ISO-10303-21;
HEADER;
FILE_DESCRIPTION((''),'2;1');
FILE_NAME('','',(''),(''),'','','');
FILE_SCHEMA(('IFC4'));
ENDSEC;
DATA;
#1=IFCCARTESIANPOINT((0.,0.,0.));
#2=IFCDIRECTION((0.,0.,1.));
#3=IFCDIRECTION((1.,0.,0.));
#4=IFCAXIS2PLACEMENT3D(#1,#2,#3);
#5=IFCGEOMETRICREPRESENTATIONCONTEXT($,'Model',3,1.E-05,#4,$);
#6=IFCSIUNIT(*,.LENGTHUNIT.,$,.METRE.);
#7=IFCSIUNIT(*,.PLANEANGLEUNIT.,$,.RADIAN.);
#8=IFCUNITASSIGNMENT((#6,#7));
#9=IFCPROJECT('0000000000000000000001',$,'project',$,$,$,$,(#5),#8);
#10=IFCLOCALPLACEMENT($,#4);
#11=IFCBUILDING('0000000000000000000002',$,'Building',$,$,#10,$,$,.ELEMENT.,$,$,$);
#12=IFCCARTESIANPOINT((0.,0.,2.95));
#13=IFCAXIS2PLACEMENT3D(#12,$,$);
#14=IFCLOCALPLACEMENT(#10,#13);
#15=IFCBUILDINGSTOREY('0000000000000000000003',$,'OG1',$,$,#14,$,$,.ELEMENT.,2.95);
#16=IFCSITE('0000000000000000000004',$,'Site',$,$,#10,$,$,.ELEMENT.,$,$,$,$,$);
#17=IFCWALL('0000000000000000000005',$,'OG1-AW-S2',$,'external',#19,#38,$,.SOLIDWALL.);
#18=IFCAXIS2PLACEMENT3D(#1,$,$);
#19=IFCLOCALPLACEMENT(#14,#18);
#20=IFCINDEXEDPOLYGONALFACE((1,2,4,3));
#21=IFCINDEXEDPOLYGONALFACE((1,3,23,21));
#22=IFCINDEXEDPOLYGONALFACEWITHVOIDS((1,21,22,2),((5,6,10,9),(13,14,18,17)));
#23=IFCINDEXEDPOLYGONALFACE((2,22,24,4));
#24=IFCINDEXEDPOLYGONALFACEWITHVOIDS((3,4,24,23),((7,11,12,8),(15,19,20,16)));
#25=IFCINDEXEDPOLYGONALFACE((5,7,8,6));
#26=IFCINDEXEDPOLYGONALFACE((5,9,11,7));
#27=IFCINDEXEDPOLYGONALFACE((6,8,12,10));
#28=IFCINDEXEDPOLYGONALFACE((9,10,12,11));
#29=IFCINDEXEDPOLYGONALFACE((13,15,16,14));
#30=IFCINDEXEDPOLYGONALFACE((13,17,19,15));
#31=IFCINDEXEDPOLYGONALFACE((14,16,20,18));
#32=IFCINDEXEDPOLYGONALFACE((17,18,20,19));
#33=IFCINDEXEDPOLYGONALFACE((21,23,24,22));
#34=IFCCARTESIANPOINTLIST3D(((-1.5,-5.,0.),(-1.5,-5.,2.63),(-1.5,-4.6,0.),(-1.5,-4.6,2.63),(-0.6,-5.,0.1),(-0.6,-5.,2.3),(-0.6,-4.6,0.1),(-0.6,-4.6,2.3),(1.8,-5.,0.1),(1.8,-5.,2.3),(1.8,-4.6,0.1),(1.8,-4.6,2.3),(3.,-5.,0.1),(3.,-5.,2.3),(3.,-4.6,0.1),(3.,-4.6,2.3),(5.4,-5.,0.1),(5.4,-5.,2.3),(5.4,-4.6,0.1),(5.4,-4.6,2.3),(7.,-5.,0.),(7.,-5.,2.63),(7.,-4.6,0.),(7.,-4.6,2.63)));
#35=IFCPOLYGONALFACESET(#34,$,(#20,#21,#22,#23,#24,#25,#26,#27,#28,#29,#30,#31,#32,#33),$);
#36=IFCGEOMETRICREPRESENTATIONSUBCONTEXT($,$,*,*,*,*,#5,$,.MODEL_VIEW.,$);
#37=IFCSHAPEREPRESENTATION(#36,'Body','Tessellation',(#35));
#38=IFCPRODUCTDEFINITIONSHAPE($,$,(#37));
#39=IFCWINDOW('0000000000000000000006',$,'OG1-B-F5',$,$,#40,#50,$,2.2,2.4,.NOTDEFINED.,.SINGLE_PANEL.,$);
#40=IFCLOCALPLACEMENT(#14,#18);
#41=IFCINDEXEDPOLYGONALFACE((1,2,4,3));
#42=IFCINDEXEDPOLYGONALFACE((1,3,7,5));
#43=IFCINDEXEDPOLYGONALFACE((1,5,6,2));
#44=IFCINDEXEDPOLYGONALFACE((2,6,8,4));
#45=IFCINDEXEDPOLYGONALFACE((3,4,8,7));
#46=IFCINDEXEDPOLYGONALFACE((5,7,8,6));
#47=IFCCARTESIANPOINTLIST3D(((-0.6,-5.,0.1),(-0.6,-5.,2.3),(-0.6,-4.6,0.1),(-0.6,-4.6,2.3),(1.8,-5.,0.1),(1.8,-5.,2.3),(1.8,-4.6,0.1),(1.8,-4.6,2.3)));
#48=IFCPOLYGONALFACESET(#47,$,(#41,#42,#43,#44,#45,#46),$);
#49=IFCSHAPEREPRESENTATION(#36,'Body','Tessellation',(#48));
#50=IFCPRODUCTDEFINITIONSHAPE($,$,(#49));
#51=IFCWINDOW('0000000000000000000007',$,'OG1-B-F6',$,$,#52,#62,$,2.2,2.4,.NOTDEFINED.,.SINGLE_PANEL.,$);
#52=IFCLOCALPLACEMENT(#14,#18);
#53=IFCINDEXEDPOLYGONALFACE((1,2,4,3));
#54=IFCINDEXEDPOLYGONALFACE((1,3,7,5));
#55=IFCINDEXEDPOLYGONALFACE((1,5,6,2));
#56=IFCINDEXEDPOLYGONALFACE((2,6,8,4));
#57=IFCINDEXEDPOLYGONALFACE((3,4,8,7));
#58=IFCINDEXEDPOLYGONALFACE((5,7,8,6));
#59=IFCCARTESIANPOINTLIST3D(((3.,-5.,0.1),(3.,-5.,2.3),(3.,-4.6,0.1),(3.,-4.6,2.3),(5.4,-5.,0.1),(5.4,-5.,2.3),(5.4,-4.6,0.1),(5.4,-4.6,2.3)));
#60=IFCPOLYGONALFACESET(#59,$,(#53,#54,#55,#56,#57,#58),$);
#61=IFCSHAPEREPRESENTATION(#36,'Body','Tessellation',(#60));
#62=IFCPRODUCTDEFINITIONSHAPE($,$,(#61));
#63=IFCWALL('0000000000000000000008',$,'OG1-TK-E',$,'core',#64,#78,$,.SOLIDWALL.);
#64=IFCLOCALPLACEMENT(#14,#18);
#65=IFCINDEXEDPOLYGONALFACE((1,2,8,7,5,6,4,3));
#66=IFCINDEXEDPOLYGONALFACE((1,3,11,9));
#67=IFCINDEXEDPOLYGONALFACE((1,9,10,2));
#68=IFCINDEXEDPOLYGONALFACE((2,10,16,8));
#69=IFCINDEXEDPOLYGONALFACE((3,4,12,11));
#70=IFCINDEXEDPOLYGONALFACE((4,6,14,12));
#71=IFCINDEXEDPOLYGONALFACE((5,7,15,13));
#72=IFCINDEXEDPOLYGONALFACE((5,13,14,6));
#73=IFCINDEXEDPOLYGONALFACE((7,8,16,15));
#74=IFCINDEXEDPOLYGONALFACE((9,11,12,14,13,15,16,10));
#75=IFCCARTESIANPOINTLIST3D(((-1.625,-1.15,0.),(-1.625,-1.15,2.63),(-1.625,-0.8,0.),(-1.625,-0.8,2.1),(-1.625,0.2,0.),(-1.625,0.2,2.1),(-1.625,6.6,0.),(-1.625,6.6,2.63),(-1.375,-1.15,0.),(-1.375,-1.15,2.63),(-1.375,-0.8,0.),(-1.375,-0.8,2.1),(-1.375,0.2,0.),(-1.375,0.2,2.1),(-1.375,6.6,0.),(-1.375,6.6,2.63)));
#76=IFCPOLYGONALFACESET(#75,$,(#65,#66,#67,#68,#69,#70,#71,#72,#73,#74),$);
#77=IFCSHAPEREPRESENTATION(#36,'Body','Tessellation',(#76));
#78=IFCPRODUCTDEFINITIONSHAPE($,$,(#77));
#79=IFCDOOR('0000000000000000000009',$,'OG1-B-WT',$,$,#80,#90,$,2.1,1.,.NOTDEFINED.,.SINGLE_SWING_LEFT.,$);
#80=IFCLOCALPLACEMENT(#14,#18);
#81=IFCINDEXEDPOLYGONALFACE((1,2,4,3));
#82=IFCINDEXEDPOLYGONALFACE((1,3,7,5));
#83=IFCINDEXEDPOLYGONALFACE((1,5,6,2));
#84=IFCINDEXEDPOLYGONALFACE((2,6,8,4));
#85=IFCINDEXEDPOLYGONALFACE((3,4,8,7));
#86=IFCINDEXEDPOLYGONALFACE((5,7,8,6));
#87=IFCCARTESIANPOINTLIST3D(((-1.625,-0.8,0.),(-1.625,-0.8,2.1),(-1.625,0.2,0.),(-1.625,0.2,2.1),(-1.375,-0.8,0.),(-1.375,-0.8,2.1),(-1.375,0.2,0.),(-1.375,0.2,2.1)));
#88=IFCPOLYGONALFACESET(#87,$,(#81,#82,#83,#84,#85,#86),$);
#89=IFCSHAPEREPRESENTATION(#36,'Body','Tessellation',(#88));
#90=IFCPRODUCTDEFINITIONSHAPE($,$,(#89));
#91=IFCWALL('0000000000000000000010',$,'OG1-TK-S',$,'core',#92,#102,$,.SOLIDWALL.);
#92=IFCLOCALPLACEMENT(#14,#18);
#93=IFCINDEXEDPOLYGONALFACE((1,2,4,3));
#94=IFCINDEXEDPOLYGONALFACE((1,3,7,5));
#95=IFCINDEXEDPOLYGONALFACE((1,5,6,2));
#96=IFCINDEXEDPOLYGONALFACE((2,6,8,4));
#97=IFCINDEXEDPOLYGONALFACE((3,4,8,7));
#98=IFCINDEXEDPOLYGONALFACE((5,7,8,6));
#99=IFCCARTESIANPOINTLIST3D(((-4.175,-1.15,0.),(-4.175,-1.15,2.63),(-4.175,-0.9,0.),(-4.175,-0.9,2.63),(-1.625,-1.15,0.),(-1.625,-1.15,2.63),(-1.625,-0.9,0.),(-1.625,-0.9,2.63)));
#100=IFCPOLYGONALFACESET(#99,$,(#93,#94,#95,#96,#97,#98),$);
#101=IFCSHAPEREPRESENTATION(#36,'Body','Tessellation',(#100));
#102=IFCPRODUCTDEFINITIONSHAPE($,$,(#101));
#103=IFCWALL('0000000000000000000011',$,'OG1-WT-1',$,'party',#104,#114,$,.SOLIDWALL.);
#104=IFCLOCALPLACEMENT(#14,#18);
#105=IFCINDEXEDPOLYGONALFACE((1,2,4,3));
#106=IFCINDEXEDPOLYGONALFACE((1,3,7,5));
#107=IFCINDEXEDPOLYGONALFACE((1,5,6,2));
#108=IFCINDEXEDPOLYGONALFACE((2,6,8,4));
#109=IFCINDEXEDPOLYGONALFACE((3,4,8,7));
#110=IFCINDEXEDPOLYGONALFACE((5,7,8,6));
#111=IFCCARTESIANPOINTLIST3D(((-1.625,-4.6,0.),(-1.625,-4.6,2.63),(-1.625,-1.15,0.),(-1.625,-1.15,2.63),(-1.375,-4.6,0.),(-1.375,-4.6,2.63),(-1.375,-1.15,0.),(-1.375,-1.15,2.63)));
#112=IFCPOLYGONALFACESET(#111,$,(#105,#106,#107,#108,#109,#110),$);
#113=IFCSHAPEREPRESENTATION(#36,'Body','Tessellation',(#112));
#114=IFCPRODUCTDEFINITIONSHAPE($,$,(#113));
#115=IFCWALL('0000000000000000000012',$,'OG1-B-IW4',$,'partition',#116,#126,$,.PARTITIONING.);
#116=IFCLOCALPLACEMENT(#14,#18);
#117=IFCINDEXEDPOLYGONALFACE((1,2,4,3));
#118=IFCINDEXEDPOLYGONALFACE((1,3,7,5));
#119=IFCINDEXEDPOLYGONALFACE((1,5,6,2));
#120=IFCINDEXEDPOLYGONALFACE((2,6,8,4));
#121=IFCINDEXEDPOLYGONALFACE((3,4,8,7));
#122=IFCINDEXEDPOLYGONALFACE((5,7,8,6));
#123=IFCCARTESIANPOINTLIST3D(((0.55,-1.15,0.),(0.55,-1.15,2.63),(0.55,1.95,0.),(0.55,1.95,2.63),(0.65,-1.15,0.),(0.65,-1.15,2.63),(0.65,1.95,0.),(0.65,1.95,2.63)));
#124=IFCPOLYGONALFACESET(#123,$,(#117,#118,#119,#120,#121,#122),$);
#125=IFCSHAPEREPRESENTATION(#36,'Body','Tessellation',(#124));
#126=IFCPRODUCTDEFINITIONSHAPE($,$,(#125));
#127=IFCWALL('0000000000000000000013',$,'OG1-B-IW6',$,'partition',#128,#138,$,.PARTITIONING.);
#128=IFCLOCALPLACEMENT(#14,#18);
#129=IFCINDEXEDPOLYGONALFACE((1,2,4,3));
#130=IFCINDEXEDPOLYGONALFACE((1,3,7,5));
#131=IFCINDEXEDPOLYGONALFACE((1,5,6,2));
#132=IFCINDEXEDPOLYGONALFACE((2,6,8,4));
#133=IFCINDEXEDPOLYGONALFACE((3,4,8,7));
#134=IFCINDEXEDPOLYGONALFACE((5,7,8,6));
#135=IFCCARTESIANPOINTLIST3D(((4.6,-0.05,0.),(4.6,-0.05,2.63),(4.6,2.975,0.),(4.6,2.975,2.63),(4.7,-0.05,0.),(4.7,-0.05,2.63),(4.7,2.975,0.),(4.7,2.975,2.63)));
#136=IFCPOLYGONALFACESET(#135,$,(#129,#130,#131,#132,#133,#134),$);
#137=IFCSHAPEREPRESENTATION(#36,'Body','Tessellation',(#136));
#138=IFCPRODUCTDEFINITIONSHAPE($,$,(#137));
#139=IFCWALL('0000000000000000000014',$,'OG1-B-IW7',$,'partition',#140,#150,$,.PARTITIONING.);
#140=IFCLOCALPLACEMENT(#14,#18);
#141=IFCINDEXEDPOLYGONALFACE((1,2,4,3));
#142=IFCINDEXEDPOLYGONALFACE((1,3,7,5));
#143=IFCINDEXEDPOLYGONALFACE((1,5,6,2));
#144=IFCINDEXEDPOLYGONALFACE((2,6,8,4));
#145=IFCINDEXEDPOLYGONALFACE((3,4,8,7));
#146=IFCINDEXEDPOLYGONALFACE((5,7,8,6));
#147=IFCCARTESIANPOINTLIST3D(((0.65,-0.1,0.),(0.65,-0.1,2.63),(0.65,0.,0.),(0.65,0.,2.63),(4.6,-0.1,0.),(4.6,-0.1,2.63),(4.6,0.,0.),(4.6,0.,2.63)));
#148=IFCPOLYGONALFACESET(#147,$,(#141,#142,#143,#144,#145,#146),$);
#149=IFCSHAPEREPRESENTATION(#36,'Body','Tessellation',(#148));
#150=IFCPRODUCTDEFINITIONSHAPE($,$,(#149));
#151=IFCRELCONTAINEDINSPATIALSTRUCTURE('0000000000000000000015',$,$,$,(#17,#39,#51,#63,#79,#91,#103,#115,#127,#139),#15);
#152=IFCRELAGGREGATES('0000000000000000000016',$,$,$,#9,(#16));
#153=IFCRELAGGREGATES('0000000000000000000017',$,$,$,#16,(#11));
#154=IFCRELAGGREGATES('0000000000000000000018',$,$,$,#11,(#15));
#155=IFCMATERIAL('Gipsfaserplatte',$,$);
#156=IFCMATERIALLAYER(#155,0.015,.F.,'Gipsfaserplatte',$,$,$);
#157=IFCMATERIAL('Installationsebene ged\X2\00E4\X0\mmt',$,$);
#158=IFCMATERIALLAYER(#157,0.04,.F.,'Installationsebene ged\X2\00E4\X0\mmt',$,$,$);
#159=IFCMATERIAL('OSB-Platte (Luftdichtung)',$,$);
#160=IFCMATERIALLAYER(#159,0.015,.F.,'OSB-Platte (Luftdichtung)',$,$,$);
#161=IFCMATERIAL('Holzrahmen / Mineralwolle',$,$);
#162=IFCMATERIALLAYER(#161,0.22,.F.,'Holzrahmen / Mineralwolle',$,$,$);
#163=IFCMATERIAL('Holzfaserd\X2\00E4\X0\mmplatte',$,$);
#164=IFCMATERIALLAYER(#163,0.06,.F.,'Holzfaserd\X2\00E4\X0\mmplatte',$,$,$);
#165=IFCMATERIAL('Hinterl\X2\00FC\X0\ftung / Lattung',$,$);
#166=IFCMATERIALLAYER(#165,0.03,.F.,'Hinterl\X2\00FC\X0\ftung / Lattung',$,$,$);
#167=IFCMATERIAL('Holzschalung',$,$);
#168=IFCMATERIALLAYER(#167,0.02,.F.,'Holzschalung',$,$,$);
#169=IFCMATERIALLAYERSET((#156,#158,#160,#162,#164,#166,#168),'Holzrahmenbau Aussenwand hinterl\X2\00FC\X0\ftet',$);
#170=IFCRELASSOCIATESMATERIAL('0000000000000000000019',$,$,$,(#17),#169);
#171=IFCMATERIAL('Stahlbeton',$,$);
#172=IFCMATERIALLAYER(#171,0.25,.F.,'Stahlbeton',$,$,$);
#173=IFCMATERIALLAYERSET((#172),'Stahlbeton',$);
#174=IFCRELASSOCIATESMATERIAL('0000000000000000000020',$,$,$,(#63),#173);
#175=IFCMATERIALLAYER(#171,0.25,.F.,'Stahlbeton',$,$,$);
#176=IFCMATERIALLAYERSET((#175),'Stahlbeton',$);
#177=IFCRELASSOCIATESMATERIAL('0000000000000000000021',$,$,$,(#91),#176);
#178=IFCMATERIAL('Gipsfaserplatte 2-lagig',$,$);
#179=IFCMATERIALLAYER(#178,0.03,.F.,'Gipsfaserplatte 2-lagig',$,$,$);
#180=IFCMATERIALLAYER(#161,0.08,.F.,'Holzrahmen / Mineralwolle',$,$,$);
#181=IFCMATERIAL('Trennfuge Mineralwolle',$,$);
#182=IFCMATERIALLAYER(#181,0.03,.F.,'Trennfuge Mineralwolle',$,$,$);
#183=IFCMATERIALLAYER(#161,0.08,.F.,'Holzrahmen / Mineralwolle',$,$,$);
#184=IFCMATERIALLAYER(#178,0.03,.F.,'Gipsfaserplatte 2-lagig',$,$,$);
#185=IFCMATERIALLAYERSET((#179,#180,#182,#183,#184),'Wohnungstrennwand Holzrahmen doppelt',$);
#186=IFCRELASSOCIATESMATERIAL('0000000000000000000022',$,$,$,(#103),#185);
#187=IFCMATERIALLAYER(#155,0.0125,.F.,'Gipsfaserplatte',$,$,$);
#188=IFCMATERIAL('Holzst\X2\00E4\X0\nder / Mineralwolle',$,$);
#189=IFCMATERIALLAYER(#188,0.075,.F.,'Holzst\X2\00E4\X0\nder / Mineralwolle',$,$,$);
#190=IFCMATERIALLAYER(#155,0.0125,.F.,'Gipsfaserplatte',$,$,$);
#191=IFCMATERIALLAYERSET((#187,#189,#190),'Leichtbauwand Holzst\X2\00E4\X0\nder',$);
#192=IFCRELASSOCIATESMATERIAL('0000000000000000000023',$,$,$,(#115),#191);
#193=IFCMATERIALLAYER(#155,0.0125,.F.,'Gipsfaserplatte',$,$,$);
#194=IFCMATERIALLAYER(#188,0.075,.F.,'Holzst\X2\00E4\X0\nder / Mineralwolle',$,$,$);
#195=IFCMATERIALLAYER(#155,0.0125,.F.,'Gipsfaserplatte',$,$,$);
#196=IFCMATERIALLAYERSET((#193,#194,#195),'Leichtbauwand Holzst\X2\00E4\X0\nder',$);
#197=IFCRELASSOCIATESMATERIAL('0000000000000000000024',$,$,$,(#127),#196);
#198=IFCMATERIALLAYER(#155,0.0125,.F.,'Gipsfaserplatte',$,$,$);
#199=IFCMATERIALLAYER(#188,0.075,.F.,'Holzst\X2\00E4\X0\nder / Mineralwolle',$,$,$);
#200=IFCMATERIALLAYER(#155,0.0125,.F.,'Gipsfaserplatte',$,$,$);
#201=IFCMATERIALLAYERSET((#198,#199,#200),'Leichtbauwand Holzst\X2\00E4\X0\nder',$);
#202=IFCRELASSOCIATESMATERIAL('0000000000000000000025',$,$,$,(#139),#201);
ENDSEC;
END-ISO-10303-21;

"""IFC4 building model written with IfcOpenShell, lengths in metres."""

from ifc_helpers import new_model, si_unit, frame, frame_2d, origin, origin_with_axes, place, context, subcontext, project, spatial, rectangle, extrude, material, layer, layer_set, element, fill, save


model = new_model("IFC4")

# Units and contexts
model_context = context("Model", 3, precision=1e-05, world=origin_with_axes())
sub_context = subcontext(model_context, None, None, "MODEL_VIEW")
ifc_project = project(units=[si_unit("LENGTHUNIT", "METRE"), si_unit("PLANEANGLEUNIT", "RADIAN")], contexts=[model_context])

# Site, building, storey
placement = place(None, origin_with_axes())
site = spatial("IfcSite", under=ifc_project, at=placement, Name="Site", CompositionType="ELEMENT")
building = spatial("IfcBuilding", under=site, at=placement, Name="Building", CompositionType="ELEMENT")
storey_placement = place(placement, frame((0.0, 0.0, 2.95)))
storey = spatial("IfcBuildingStorey", under=building, at=storey_placement, Name="OG1", CompositionType="ELEMENT", Elevation=2.95)

# Wall, openings, windows
ifc_material_1 = material(Name="Gipsfaserplatte")
ifc_layer_1 = layer(ifc_material_1, 0.015, ventilated=False, Name="Gipsfaserplatte")
ifc_material_2 = material(Name="Installationsebene gedämmt")
ifc_layer_2 = layer(ifc_material_2, 0.04, ventilated=False, Name="Installationsebene gedämmt")
ifc_material_3 = material(Name="OSB-Platte (Luftdichtung)")
ifc_layer_3 = layer(ifc_material_3, 0.015, ventilated=False, Name="OSB-Platte (Luftdichtung)")
ifc_material_4 = material(Name="Holzrahmen / Mineralwolle")
ifc_layer_4 = layer(ifc_material_4, 0.22, ventilated=False, Name="Holzrahmen / Mineralwolle")
ifc_material_5 = material(Name="Holzfaserdämmplatte")
ifc_layer_5 = layer(ifc_material_5, 0.06, ventilated=False, Name="Holzfaserdämmplatte")
ifc_material_6 = material(Name="Hinterlüftung / Lattung")
ifc_layer_6 = layer(ifc_material_6, 0.03, ventilated=False, Name="Hinterlüftung / Lattung")
ifc_material_7 = material(Name="Holzschalung")
ifc_layer_7 = layer(ifc_material_7, 0.02, ventilated=False, Name="Holzschalung")
ifc_layer_set_1 = layer_set([ifc_layer_1, ifc_layer_2, ifc_layer_3, ifc_layer_4, ifc_layer_5, ifc_layer_6, ifc_layer_7], Name="Holzrahmenbau Aussenwand hinterlüftet")
wall_1_placement = place(storey_placement, frame((7.0, -4.8, 0.0), z_axis=(0.0, 0.0, 1.0), x_axis=(-1.0, 0.0, 0.0)))
wall_1 = element("IfcWall", 1, at=wall_1_placement, inside=storey, material=ifc_layer_set_1, Name="OG1-AW-S2", ObjectType="external", PredefinedType="SOLIDWALL", context=sub_context, shape_type="SweptSolid", body=[
    extrude(rectangle(XDim=8.5, YDim=0.4, at=frame_2d((4.25, 0.0))), origin(), (0.0, 0.0, 1.0), 2.63),
])
opening_1_placement = place(wall_1_placement, frame((6.4, 0.25, 0.1), z_axis=(0.0, -1.0, 0.0), x_axis=(1.0, 0.0, 0.0)))
opening_1 = element("IfcOpeningElement", 2, at=opening_1_placement, cuts=wall_1, PredefinedType="OPENING", context=sub_context, shape_type="SweptSolid", body=[
    extrude(rectangle(XDim=2.4, YDim=2.2, at=frame_2d((0.0, 1.1))), origin(), (0.0, 0.0, 1.0), 0.5),
])
opening_2_placement = place(wall_1_placement, frame((2.8, 0.25, 0.1), z_axis=(0.0, -1.0, 0.0), x_axis=(1.0, 0.0, 0.0)))
opening_2 = element("IfcOpeningElement", 3, at=opening_2_placement, cuts=wall_1, PredefinedType="OPENING", context=sub_context, shape_type="SweptSolid", body=[
    extrude(rectangle(XDim=2.4, YDim=2.2, at=frame_2d((0.0, 1.1))), origin(), (0.0, 0.0, 1.0), 0.5),
])
window_1_placement = place(wall_1_placement, frame((6.4, 0.2, 0.1), z_axis=(0.0, -1.0, 0.0), x_axis=(1.0, 0.0, 0.0)))
window_1 = element("IfcWindow", 4, at=window_1_placement, inside=storey, Name="OG1-B-F5", OverallHeight=2.2, OverallWidth=2.4, PartitioningType="SINGLE_PANEL", PredefinedType="NOTDEFINED", context=sub_context, shape_type="SweptSolid", body=[
    extrude(rectangle(XDim=2.4, YDim=2.2, at=frame_2d((0.0, 1.1))), origin(), (0.0, 0.0, 1.0), 0.4),
])
fill(opening_1, window_1)
window_2_placement = place(wall_1_placement, frame((2.8, 0.2, 0.1), z_axis=(0.0, -1.0, 0.0), x_axis=(1.0, 0.0, 0.0)))
window_2 = element("IfcWindow", 5, at=window_2_placement, inside=storey, Name="OG1-B-F6", OverallHeight=2.2, OverallWidth=2.4, PartitioningType="SINGLE_PANEL", PredefinedType="NOTDEFINED", context=sub_context, shape_type="SweptSolid", body=[
    extrude(rectangle(XDim=2.4, YDim=2.2, at=frame_2d((0.0, 1.1))), origin(), (0.0, 0.0, 1.0), 0.4),
])
fill(opening_2, window_2)

# Wall, opening, door
ifc_material_8 = material(Name="Stahlbeton")
ifc_layer_8 = layer(ifc_material_8, 0.25, ventilated=False, Name="Stahlbeton")
ifc_layer_set_2 = layer_set([ifc_layer_8], Name="Stahlbeton")
wall_2_placement = place(storey_placement, frame((-1.5, -1.15, 0.0), z_axis=(0.0, 0.0, 1.0), x_axis=(0.0, 1.0, 0.0)))
wall_2 = element("IfcWall", 6, at=wall_2_placement, inside=storey, material=ifc_layer_set_2, Name="OG1-TK-E", ObjectType="core", PredefinedType="SOLIDWALL", context=sub_context, shape_type="SweptSolid", body=[
    extrude(rectangle(XDim=7.75, YDim=0.25, at=frame_2d((3.875, 0.0))), origin(), (0.0, 0.0, 1.0), 2.63),
])
opening_3_placement = place(wall_2_placement, frame((0.85, 0.175, 0.0), z_axis=(0.0, -1.0, 0.0), x_axis=(1.0, 0.0, 0.0)))
opening_3 = element("IfcOpeningElement", 7, at=opening_3_placement, cuts=wall_2, PredefinedType="OPENING", context=sub_context, shape_type="SweptSolid", body=[
    extrude(rectangle(XDim=1.0, YDim=2.1, at=frame_2d((0.0, 1.05))), origin(), (0.0, 0.0, 1.0), 0.35),
])
door_1_placement = place(wall_2_placement, frame((0.85, 0.125, 0.0), z_axis=(0.0, -1.0, 0.0), x_axis=(1.0, 0.0, 0.0)))
door_1 = element("IfcDoor", 8, at=door_1_placement, inside=storey, Name="OG1-B-WT", OperationType="SINGLE_SWING_LEFT", OverallHeight=2.1, OverallWidth=1.0, PredefinedType="NOTDEFINED", context=sub_context, shape_type="SweptSolid", body=[
    extrude(rectangle(XDim=1.0, YDim=2.1, at=frame_2d((0.0, 1.05))), origin(), (0.0, 0.0, 1.0), 0.25),
])
fill(opening_3, door_1)

# Walls
ifc_layer_9 = layer(ifc_material_8, 0.25, ventilated=False, Name="Stahlbeton")
ifc_layer_set_3 = layer_set([ifc_layer_9], Name="Stahlbeton")
wall_3_placement = place(storey_placement, frame((-4.175, -1.025, 0.0), z_axis=(0.0, 0.0, 1.0), x_axis=(1.0, 0.0, 0.0)))
element("IfcWall", 9, at=wall_3_placement, inside=storey, material=ifc_layer_set_3, Name="OG1-TK-S", ObjectType="core", PredefinedType="SOLIDWALL", context=sub_context, shape_type="SweptSolid", body=[
    extrude(rectangle(XDim=2.55, YDim=0.25, at=frame_2d((1.275, 0.0))), origin(), (0.0, 0.0, 1.0), 2.63),
])
ifc_material_9 = material(Name="Gipsfaserplatte 2-lagig")
ifc_layer_10 = layer(ifc_material_9, 0.03, ventilated=False, Name="Gipsfaserplatte 2-lagig")
ifc_layer_11 = layer(ifc_material_4, 0.08, ventilated=False, Name="Holzrahmen / Mineralwolle")
ifc_material_10 = material(Name="Trennfuge Mineralwolle")
ifc_layer_12 = layer(ifc_material_10, 0.03, ventilated=False, Name="Trennfuge Mineralwolle")
ifc_layer_13 = layer(ifc_material_4, 0.08, ventilated=False, Name="Holzrahmen / Mineralwolle")
ifc_layer_14 = layer(ifc_material_9, 0.03, ventilated=False, Name="Gipsfaserplatte 2-lagig")
ifc_layer_set_4 = layer_set([ifc_layer_10, ifc_layer_11, ifc_layer_12, ifc_layer_13, ifc_layer_14], Name="Wohnungstrennwand Holzrahmen doppelt")
wall_4_placement = place(storey_placement, frame((-1.5, -1.15, 0.0), z_axis=(0.0, 0.0, 1.0), x_axis=(0.0, -1.0, 0.0)))
element("IfcWall", 10, at=wall_4_placement, inside=storey, material=ifc_layer_set_4, Name="OG1-WT-1", ObjectType="party", PredefinedType="SOLIDWALL", context=sub_context, shape_type="SweptSolid", body=[
    extrude(rectangle(XDim=3.45, YDim=0.25, at=frame_2d((1.725, 0.0))), origin(), (0.0, 0.0, 1.0), 2.63),
])
ifc_layer_15 = layer(ifc_material_1, 0.0125, ventilated=False, Name="Gipsfaserplatte")
ifc_material_11 = material(Name="Holzständer / Mineralwolle")
ifc_layer_16 = layer(ifc_material_11, 0.075, ventilated=False, Name="Holzständer / Mineralwolle")
ifc_layer_17 = layer(ifc_material_1, 0.0125, ventilated=False, Name="Gipsfaserplatte")
ifc_layer_set_5 = layer_set([ifc_layer_15, ifc_layer_16, ifc_layer_17], Name="Leichtbauwand Holzständer")
wall_5_placement = place(storey_placement, frame((0.6, -1.15, 0.0), z_axis=(0.0, 0.0, 1.0), x_axis=(0.0, 1.0, 0.0)))
element("IfcWall", 11, at=wall_5_placement, inside=storey, material=ifc_layer_set_5, Name="OG1-B-IW4", ObjectType="partition", PredefinedType="PARTITIONING", context=sub_context, shape_type="SweptSolid", body=[
    extrude(rectangle(XDim=3.1, YDim=0.1, at=frame_2d((1.55, 0.0))), origin(), (0.0, 0.0, 1.0), 2.63),
])
ifc_layer_18 = layer(ifc_material_1, 0.0125, ventilated=False, Name="Gipsfaserplatte")
ifc_layer_19 = layer(ifc_material_11, 0.075, ventilated=False, Name="Holzständer / Mineralwolle")
ifc_layer_20 = layer(ifc_material_1, 0.0125, ventilated=False, Name="Gipsfaserplatte")
ifc_layer_set_6 = layer_set([ifc_layer_18, ifc_layer_19, ifc_layer_20], Name="Leichtbauwand Holzständer")
wall_6_placement = place(storey_placement, frame((4.65, -0.05, 0.0), z_axis=(0.0, 0.0, 1.0), x_axis=(0.0, 1.0, 0.0)))
element("IfcWall", 12, at=wall_6_placement, inside=storey, material=ifc_layer_set_6, Name="OG1-B-IW6", ObjectType="partition", PredefinedType="PARTITIONING", context=sub_context, shape_type="SweptSolid", body=[
    extrude(rectangle(XDim=3.025, YDim=0.1, at=frame_2d((1.5125, 0.0))), origin(), (0.0, 0.0, 1.0), 2.63),
])
ifc_layer_21 = layer(ifc_material_1, 0.0125, ventilated=False, Name="Gipsfaserplatte")
ifc_layer_22 = layer(ifc_material_11, 0.075, ventilated=False, Name="Holzständer / Mineralwolle")
ifc_layer_23 = layer(ifc_material_1, 0.0125, ventilated=False, Name="Gipsfaserplatte")
ifc_layer_set_7 = layer_set([ifc_layer_21, ifc_layer_22, ifc_layer_23], Name="Leichtbauwand Holzständer")
wall_7_placement = place(storey_placement, frame((0.65, -0.05, 0.0), z_axis=(0.0, 0.0, 1.0), x_axis=(1.0, 0.0, 0.0)))
element("IfcWall", 13, at=wall_7_placement, inside=storey, material=ifc_layer_set_7, Name="OG1-B-IW7", ObjectType="partition", PredefinedType="PARTITIONING", context=sub_context, shape_type="SweptSolid", body=[
    extrude(rectangle(XDim=3.95, YDim=0.1, at=frame_2d((1.975, 0.0))), origin(), (0.0, 0.0, 1.0), 2.63),
])

save(model, "model.ifc")
